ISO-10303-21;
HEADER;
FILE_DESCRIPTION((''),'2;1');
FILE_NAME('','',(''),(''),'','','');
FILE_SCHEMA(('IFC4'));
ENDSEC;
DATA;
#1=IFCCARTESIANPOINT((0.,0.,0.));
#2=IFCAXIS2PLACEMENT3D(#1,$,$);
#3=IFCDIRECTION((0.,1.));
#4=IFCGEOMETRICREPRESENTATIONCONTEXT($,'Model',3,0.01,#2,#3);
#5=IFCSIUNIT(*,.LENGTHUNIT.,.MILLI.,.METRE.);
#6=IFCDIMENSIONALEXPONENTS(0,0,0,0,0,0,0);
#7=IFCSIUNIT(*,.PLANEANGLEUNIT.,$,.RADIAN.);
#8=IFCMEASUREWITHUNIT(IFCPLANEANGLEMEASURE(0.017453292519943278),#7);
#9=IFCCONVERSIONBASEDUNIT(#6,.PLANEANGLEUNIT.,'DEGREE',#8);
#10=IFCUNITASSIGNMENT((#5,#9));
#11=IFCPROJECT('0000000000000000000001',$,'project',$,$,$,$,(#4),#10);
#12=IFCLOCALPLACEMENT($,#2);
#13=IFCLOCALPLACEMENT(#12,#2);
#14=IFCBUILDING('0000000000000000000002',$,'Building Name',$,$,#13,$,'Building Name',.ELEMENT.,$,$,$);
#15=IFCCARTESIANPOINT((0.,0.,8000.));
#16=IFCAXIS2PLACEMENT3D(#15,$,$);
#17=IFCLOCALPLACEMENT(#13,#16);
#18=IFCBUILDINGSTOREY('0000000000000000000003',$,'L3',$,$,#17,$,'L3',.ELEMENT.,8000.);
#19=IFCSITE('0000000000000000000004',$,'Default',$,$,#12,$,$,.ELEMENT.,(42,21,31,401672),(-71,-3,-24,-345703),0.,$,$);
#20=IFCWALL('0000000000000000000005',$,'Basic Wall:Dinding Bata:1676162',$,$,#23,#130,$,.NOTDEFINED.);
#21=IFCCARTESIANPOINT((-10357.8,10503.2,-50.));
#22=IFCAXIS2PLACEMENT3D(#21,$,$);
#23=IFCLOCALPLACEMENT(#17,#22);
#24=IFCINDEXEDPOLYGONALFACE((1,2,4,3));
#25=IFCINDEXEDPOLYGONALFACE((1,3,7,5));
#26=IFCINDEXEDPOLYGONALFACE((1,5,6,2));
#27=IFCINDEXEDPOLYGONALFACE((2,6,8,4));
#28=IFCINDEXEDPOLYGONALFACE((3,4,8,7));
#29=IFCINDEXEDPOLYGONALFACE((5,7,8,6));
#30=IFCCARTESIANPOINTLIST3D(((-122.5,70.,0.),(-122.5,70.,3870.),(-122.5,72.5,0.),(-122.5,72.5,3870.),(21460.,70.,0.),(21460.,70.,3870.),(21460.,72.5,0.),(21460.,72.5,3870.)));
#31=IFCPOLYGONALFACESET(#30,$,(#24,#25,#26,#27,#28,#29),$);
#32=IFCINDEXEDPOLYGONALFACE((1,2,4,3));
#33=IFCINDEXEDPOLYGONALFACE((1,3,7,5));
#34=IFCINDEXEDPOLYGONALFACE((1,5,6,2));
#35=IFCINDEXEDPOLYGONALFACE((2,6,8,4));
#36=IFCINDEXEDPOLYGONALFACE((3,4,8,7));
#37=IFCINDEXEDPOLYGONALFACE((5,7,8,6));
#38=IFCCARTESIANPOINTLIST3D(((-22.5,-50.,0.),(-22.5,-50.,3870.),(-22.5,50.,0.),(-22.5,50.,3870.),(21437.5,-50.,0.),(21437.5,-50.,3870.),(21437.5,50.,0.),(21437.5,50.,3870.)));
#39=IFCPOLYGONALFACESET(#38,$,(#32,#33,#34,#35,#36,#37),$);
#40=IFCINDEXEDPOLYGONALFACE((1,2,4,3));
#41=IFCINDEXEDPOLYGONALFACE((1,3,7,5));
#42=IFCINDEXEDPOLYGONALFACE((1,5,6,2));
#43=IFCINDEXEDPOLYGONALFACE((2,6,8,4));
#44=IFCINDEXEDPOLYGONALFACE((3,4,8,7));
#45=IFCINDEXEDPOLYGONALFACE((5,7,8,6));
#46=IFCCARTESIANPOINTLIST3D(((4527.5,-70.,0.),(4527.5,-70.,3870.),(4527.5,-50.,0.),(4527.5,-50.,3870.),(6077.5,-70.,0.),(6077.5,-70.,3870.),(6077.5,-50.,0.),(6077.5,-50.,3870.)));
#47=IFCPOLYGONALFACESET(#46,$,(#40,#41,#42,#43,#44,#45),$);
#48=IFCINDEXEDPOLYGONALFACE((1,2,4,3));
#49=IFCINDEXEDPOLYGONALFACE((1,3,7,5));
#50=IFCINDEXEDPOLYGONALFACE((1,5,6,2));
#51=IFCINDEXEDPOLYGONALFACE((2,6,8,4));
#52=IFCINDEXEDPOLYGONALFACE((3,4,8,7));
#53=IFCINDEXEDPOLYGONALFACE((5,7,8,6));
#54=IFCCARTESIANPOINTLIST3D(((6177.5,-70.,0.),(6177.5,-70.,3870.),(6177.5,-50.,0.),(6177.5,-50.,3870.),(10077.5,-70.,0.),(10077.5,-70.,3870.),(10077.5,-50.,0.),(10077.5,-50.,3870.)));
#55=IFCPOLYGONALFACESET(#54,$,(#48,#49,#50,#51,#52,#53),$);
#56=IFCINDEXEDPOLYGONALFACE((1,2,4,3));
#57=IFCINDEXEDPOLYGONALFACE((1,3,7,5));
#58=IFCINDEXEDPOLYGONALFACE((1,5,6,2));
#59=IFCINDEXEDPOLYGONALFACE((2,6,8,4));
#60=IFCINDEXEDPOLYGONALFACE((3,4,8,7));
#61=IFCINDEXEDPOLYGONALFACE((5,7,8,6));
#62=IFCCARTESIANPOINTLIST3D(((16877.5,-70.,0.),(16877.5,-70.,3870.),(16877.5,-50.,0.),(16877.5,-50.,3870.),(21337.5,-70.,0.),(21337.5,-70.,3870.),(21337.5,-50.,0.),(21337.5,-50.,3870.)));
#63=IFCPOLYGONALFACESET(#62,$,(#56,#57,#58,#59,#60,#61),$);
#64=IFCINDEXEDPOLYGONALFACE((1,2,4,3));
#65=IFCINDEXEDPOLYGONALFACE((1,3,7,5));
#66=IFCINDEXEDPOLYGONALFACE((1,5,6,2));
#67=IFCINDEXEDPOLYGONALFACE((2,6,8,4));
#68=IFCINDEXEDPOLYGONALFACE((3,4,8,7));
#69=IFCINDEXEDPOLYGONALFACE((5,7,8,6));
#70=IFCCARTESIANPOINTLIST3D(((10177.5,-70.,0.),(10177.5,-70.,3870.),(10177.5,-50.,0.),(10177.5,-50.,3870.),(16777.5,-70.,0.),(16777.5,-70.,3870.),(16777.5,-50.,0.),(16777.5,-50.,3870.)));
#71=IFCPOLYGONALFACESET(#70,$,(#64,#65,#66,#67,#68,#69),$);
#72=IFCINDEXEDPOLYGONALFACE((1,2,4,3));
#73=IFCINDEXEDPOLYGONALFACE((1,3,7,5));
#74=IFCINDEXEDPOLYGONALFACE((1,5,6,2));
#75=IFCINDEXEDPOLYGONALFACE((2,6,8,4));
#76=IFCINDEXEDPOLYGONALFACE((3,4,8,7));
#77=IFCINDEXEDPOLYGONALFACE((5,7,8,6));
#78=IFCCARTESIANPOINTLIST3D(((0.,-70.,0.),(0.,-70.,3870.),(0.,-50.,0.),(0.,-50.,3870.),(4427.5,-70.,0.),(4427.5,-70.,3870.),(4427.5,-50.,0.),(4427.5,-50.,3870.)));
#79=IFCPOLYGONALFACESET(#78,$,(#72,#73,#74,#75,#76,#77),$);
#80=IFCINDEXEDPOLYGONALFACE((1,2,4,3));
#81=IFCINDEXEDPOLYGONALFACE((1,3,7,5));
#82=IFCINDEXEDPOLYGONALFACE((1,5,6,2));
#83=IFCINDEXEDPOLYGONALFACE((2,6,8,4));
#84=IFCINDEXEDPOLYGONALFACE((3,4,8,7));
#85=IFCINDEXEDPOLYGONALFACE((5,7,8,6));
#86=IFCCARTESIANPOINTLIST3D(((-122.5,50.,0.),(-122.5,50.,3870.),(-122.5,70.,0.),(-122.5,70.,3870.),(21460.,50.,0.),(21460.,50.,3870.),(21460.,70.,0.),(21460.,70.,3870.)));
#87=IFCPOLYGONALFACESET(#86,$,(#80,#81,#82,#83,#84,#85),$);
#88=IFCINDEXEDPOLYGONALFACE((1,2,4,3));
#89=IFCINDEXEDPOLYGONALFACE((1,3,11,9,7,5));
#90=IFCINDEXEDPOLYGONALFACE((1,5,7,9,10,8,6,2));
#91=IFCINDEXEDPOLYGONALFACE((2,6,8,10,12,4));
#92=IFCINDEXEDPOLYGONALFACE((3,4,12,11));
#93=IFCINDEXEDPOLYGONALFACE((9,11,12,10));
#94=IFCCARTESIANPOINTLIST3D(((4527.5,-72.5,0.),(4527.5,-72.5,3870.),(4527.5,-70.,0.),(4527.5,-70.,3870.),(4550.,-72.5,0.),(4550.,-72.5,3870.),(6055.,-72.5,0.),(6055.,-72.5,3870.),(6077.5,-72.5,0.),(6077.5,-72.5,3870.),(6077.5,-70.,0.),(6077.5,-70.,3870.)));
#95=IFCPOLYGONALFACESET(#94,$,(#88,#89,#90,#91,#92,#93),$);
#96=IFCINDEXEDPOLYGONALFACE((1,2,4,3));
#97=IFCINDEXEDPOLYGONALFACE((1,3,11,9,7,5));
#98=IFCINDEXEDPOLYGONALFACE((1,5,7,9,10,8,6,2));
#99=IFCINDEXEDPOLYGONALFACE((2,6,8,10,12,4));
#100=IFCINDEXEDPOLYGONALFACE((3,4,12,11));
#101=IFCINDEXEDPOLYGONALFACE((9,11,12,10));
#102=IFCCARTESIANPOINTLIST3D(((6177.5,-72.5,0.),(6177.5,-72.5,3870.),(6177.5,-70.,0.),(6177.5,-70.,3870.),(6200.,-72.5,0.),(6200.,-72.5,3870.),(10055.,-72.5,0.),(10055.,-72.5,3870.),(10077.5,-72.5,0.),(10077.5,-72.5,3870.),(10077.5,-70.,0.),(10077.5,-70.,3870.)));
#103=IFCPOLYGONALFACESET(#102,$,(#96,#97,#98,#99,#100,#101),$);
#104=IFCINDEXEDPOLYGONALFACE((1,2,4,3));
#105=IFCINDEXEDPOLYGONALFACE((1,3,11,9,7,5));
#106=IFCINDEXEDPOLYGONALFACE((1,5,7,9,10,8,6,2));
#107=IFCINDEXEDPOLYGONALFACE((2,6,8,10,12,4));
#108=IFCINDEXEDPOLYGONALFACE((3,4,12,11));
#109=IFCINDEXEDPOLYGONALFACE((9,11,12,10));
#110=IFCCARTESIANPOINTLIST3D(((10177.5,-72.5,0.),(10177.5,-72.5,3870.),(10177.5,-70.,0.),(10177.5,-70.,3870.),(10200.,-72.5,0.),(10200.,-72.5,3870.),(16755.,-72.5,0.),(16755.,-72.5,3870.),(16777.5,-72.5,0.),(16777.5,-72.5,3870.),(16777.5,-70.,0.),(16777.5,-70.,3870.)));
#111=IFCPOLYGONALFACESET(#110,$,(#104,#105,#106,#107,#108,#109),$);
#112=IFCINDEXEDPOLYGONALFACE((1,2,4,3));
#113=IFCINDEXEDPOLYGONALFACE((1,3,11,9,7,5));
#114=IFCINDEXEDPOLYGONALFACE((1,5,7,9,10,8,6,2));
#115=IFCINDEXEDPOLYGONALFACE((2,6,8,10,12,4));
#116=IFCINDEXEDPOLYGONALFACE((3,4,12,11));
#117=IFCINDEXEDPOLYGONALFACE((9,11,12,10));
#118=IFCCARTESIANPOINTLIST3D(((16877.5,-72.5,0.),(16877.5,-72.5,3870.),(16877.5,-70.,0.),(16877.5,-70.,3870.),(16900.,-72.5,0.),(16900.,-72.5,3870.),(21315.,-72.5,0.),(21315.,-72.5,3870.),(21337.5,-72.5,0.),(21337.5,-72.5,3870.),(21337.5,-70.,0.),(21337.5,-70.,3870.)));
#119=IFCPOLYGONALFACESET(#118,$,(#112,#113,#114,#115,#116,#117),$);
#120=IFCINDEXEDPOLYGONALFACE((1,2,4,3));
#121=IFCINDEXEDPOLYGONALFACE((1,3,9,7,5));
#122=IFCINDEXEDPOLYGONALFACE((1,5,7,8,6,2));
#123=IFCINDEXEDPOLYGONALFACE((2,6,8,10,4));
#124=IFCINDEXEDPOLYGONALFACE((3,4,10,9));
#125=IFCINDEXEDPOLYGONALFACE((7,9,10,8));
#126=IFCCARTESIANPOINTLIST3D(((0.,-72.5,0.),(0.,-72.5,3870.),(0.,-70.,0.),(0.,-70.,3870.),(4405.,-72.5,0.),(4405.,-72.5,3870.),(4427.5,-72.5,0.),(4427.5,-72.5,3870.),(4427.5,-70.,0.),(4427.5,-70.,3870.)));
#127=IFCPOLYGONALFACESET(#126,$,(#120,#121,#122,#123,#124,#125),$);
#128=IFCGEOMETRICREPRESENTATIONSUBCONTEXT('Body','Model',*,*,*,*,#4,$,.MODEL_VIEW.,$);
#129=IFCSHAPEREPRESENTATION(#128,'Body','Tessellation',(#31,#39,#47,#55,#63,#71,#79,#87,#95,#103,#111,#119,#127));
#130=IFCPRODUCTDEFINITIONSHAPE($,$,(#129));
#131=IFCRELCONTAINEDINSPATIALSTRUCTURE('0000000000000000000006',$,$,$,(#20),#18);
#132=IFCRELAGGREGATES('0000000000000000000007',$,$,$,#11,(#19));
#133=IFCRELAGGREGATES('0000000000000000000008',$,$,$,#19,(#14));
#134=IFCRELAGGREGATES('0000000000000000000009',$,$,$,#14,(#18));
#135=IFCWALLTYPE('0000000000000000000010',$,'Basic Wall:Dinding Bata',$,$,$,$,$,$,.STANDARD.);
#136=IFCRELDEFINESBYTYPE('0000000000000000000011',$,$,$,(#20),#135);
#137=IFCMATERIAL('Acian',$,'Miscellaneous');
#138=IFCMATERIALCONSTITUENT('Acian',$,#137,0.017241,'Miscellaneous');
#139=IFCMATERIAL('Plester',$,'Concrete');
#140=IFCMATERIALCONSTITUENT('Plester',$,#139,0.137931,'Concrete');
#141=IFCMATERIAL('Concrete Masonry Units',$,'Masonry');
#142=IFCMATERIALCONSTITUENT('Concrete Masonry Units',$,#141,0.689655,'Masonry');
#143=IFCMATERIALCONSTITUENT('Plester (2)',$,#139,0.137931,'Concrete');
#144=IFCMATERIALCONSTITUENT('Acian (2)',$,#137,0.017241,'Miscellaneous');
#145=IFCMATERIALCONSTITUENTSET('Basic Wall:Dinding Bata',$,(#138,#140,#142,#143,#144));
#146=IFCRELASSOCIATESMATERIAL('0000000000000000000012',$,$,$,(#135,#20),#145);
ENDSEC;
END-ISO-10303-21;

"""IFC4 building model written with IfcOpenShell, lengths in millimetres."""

from ifc_helpers import new_model, entity, si_unit, converted_unit, direction, frame, origin, place, context, subcontext, project, spatial, indexed_curve, outline, extrude, material, constituent, constituent_set, type_object, element, save


model = new_model("IFC4")

# Units and contexts
model_context = context("Model", 3, precision=0.01, world=origin(), true_north=direction((0.0, 1.0)))
body_context = subcontext(model_context, "Body", "Model", "MODEL_VIEW")
ifc_project = project(units=[si_unit("LENGTHUNIT", "METRE", prefix="MILLI"), converted_unit("PLANEANGLEUNIT", "DEGREE", entity("IfcPlaneAngleMeasure", 0.017453292519943278), si_unit("PLANEANGLEUNIT", "RADIAN"), dimensions=[0, 0, 0, 0, 0, 0, 0])], contexts=[model_context])

# Site, building, storey
site_placement = place(None, origin())
site = spatial("IfcSite", under=ifc_project, at=site_placement, Name="Default", CompositionType="ELEMENT", RefLatitude=(42, 21, 31, 401672), RefLongitude=(-71, -3, -24, -345703), RefElevation=0.0)
building_placement = place(site_placement, origin())
building = spatial("IfcBuilding", under=site, at=building_placement, Name="Building Name", LongName="Building Name", CompositionType="ELEMENT")
storey_placement = place(building_placement, frame((0.0, 0.0, 8000.0)))
storey = spatial("IfcBuildingStorey", under=building, at=storey_placement, Name="L3", LongName="L3", CompositionType="ELEMENT", Elevation=8000.0)

# Wall
ifc_material_1 = material(Name="Acian", Category="Miscellaneous")
ifc_constituent_1 = constituent(ifc_material_1, Name="Acian", Category="Miscellaneous", fraction=0.017241)
ifc_material_2 = material(Name="Plester", Category="Concrete")
ifc_constituent_2 = constituent(ifc_material_2, Name="Plester", Category="Concrete", fraction=0.137931)
ifc_material_3 = material(Name="Concrete Masonry Units", Category="Masonry")
ifc_constituent_3 = constituent(ifc_material_3, Name="Concrete Masonry Units", Category="Masonry", fraction=0.689655)
ifc_constituent_4 = constituent(ifc_material_2, Name="Plester (2)", Category="Concrete", fraction=0.137931)
ifc_constituent_5 = constituent(ifc_material_1, Name="Acian (2)", Category="Miscellaneous", fraction=0.017241)
ifc_constituent_set = constituent_set(constituents=[ifc_constituent_1, ifc_constituent_2, ifc_constituent_3, ifc_constituent_4, ifc_constituent_5], Name="Basic Wall:Dinding Bata")
wall_type = type_object("IfcWallType", Name="Basic Wall:Dinding Bata", PredefinedType="STANDARD", material=ifc_constituent_set)
wall_1_placement = place(storey_placement, frame((-10357.8, 10503.2, -50.0)))
element("IfcWall", 1, at=wall_1_placement, inside=storey, type_object=wall_type, material=ifc_constituent_set, Name="Basic Wall:Dinding Bata:1676162", PredefinedType="NOTDEFINED", context=body_context, shape_type="SweptSolid", body=[
    extrude(outline(indexed_curve([(-1.3, -10791.2), (1.2, -10791.2), (1.3, 10791.2), (-1.2, 10791.2), (-1.3, -10791.2)], self_intersect=False)), frame((10668.8, 71.2, 0.0), z_axis=(0.0, 0.0, 1.0), x_axis=(0.0, -1.0, 0.0)), (0.0, 0.0, 1.0), 3870.0),
    extrude(outline(indexed_curve([(-10730.0, -50.0), (10730.0, -50.0), (10730.0, 50.0), (-10730.0, 50.0), (-10730.0, -50.0)], self_intersect=False)), frame((10707.5, 0.0, 0.0)), (0.0, 0.0, 1.0), 3870.0),
    extrude(outline(indexed_curve([(-775.0, -10.0), (775.0, -10.0), (775.0, 10.0), (-775.0, 10.0), (-775.0, -10.0)], self_intersect=False)), frame((5302.5, -60.0, 0.0), z_axis=(0.0, 0.0, 1.0), x_axis=(-1.0, 0.0, 0.0)), (0.0, 0.0, 1.0), 3870.0),
    extrude(outline(indexed_curve([(-1950.0, -10.0), (1950.0, -10.0), (1950.0, 10.0), (-1950.0, 10.0), (-1950.0, -10.0)], self_intersect=False)), frame((8127.5, -60.0, 0.0), z_axis=(0.0, 0.0, 1.0), x_axis=(-1.0, 0.0, 0.0)), (0.0, 0.0, 1.0), 3870.0),
    extrude(outline(indexed_curve([(-2230.0, -10.0), (2230.0, -10.0), (2230.0, 10.0), (-2230.0, 10.0), (-2230.0, -10.0)], self_intersect=False)), frame((19107.5, -60.0, 0.0), z_axis=(0.0, 0.0, 1.0), x_axis=(-1.0, 0.0, 0.0)), (0.0, 0.0, 1.0), 3870.0),
    extrude(outline(indexed_curve([(-3300.0, -10.0), (3300.0, -10.0), (3300.0, 10.0), (-3300.0, 10.0), (-3300.0, -10.0)], self_intersect=False)), frame((13477.5, -60.0, 0.0), z_axis=(0.0, 0.0, 1.0), x_axis=(-1.0, 0.0, 0.0)), (0.0, 0.0, 1.0), 3870.0),
    extrude(outline(indexed_curve([(-2213.8, -10.0), (2213.8, -10.0), (2213.8, 10.0), (-2213.8, 10.0), (-2213.8, -10.0)], self_intersect=False)), frame((2213.8, -60.0, 0.0)), (0.0, 0.0, 1.0), 3870.0),
    extrude(outline(indexed_curve([(-10791.3, -10.0), (10791.2, -10.0), (10791.3, 10.0), (-10791.2, 10.0), (-10791.3, -10.0)], self_intersect=False)), frame((10668.8, 60.0, 0.0)), (0.0, 0.0, 1.0), 3870.0),
    extrude(outline(indexed_curve([(752.5, -0.8), (775.0, -0.8), (775.0, 1.7), (-775.0, 1.7), (-775.0, -0.8), (-752.5, -0.8), (752.5, -0.8)], self_intersect=False)), frame((5302.5, -71.7, 0.0)), (0.0, 0.0, 1.0), 3870.0),
    extrude(outline(indexed_curve([(1927.5, -0.8), (1950.0, -0.8), (1950.0, 1.7), (-1950.0, 1.7), (-1950.0, -0.8), (-1927.5, -0.8), (1927.5, -0.8)], self_intersect=False)), frame((8127.5, -71.7, 0.0)), (0.0, 0.0, 1.0), 3870.0),
    extrude(outline(indexed_curve([(3277.5, -0.8), (3300.0, -0.8), (3300.0, 1.7), (-3300.0, 1.7), (-3300.0, -0.8), (-3277.5, -0.8), (3277.5, -0.8)], self_intersect=False)), frame((13477.5, -71.7, 0.0)), (0.0, 0.0, 1.0), 3870.0),
    extrude(outline(indexed_curve([(2207.5, -0.8), (2230.0, -0.8), (2230.0, 1.7), (-2230.0, 1.7), (-2230.0, -0.8), (-2207.5, -0.8), (2207.5, -0.8)], self_intersect=False)), frame((19107.5, -71.7, 0.0)), (0.0, 0.0, 1.0), 3870.0),
    extrude(outline(indexed_curve([(1753.0, -1.0), (1775.5, -1.0), (1775.5, 1.5), (-2652.0, 1.5), (-2652.0, -1.0), (1753.0, -1.0)], self_intersect=False)), frame((2652.0, -71.5, 0.0)), (0.0, 0.0, 1.0), 3870.0),
])

save(model, "model.ifc")
